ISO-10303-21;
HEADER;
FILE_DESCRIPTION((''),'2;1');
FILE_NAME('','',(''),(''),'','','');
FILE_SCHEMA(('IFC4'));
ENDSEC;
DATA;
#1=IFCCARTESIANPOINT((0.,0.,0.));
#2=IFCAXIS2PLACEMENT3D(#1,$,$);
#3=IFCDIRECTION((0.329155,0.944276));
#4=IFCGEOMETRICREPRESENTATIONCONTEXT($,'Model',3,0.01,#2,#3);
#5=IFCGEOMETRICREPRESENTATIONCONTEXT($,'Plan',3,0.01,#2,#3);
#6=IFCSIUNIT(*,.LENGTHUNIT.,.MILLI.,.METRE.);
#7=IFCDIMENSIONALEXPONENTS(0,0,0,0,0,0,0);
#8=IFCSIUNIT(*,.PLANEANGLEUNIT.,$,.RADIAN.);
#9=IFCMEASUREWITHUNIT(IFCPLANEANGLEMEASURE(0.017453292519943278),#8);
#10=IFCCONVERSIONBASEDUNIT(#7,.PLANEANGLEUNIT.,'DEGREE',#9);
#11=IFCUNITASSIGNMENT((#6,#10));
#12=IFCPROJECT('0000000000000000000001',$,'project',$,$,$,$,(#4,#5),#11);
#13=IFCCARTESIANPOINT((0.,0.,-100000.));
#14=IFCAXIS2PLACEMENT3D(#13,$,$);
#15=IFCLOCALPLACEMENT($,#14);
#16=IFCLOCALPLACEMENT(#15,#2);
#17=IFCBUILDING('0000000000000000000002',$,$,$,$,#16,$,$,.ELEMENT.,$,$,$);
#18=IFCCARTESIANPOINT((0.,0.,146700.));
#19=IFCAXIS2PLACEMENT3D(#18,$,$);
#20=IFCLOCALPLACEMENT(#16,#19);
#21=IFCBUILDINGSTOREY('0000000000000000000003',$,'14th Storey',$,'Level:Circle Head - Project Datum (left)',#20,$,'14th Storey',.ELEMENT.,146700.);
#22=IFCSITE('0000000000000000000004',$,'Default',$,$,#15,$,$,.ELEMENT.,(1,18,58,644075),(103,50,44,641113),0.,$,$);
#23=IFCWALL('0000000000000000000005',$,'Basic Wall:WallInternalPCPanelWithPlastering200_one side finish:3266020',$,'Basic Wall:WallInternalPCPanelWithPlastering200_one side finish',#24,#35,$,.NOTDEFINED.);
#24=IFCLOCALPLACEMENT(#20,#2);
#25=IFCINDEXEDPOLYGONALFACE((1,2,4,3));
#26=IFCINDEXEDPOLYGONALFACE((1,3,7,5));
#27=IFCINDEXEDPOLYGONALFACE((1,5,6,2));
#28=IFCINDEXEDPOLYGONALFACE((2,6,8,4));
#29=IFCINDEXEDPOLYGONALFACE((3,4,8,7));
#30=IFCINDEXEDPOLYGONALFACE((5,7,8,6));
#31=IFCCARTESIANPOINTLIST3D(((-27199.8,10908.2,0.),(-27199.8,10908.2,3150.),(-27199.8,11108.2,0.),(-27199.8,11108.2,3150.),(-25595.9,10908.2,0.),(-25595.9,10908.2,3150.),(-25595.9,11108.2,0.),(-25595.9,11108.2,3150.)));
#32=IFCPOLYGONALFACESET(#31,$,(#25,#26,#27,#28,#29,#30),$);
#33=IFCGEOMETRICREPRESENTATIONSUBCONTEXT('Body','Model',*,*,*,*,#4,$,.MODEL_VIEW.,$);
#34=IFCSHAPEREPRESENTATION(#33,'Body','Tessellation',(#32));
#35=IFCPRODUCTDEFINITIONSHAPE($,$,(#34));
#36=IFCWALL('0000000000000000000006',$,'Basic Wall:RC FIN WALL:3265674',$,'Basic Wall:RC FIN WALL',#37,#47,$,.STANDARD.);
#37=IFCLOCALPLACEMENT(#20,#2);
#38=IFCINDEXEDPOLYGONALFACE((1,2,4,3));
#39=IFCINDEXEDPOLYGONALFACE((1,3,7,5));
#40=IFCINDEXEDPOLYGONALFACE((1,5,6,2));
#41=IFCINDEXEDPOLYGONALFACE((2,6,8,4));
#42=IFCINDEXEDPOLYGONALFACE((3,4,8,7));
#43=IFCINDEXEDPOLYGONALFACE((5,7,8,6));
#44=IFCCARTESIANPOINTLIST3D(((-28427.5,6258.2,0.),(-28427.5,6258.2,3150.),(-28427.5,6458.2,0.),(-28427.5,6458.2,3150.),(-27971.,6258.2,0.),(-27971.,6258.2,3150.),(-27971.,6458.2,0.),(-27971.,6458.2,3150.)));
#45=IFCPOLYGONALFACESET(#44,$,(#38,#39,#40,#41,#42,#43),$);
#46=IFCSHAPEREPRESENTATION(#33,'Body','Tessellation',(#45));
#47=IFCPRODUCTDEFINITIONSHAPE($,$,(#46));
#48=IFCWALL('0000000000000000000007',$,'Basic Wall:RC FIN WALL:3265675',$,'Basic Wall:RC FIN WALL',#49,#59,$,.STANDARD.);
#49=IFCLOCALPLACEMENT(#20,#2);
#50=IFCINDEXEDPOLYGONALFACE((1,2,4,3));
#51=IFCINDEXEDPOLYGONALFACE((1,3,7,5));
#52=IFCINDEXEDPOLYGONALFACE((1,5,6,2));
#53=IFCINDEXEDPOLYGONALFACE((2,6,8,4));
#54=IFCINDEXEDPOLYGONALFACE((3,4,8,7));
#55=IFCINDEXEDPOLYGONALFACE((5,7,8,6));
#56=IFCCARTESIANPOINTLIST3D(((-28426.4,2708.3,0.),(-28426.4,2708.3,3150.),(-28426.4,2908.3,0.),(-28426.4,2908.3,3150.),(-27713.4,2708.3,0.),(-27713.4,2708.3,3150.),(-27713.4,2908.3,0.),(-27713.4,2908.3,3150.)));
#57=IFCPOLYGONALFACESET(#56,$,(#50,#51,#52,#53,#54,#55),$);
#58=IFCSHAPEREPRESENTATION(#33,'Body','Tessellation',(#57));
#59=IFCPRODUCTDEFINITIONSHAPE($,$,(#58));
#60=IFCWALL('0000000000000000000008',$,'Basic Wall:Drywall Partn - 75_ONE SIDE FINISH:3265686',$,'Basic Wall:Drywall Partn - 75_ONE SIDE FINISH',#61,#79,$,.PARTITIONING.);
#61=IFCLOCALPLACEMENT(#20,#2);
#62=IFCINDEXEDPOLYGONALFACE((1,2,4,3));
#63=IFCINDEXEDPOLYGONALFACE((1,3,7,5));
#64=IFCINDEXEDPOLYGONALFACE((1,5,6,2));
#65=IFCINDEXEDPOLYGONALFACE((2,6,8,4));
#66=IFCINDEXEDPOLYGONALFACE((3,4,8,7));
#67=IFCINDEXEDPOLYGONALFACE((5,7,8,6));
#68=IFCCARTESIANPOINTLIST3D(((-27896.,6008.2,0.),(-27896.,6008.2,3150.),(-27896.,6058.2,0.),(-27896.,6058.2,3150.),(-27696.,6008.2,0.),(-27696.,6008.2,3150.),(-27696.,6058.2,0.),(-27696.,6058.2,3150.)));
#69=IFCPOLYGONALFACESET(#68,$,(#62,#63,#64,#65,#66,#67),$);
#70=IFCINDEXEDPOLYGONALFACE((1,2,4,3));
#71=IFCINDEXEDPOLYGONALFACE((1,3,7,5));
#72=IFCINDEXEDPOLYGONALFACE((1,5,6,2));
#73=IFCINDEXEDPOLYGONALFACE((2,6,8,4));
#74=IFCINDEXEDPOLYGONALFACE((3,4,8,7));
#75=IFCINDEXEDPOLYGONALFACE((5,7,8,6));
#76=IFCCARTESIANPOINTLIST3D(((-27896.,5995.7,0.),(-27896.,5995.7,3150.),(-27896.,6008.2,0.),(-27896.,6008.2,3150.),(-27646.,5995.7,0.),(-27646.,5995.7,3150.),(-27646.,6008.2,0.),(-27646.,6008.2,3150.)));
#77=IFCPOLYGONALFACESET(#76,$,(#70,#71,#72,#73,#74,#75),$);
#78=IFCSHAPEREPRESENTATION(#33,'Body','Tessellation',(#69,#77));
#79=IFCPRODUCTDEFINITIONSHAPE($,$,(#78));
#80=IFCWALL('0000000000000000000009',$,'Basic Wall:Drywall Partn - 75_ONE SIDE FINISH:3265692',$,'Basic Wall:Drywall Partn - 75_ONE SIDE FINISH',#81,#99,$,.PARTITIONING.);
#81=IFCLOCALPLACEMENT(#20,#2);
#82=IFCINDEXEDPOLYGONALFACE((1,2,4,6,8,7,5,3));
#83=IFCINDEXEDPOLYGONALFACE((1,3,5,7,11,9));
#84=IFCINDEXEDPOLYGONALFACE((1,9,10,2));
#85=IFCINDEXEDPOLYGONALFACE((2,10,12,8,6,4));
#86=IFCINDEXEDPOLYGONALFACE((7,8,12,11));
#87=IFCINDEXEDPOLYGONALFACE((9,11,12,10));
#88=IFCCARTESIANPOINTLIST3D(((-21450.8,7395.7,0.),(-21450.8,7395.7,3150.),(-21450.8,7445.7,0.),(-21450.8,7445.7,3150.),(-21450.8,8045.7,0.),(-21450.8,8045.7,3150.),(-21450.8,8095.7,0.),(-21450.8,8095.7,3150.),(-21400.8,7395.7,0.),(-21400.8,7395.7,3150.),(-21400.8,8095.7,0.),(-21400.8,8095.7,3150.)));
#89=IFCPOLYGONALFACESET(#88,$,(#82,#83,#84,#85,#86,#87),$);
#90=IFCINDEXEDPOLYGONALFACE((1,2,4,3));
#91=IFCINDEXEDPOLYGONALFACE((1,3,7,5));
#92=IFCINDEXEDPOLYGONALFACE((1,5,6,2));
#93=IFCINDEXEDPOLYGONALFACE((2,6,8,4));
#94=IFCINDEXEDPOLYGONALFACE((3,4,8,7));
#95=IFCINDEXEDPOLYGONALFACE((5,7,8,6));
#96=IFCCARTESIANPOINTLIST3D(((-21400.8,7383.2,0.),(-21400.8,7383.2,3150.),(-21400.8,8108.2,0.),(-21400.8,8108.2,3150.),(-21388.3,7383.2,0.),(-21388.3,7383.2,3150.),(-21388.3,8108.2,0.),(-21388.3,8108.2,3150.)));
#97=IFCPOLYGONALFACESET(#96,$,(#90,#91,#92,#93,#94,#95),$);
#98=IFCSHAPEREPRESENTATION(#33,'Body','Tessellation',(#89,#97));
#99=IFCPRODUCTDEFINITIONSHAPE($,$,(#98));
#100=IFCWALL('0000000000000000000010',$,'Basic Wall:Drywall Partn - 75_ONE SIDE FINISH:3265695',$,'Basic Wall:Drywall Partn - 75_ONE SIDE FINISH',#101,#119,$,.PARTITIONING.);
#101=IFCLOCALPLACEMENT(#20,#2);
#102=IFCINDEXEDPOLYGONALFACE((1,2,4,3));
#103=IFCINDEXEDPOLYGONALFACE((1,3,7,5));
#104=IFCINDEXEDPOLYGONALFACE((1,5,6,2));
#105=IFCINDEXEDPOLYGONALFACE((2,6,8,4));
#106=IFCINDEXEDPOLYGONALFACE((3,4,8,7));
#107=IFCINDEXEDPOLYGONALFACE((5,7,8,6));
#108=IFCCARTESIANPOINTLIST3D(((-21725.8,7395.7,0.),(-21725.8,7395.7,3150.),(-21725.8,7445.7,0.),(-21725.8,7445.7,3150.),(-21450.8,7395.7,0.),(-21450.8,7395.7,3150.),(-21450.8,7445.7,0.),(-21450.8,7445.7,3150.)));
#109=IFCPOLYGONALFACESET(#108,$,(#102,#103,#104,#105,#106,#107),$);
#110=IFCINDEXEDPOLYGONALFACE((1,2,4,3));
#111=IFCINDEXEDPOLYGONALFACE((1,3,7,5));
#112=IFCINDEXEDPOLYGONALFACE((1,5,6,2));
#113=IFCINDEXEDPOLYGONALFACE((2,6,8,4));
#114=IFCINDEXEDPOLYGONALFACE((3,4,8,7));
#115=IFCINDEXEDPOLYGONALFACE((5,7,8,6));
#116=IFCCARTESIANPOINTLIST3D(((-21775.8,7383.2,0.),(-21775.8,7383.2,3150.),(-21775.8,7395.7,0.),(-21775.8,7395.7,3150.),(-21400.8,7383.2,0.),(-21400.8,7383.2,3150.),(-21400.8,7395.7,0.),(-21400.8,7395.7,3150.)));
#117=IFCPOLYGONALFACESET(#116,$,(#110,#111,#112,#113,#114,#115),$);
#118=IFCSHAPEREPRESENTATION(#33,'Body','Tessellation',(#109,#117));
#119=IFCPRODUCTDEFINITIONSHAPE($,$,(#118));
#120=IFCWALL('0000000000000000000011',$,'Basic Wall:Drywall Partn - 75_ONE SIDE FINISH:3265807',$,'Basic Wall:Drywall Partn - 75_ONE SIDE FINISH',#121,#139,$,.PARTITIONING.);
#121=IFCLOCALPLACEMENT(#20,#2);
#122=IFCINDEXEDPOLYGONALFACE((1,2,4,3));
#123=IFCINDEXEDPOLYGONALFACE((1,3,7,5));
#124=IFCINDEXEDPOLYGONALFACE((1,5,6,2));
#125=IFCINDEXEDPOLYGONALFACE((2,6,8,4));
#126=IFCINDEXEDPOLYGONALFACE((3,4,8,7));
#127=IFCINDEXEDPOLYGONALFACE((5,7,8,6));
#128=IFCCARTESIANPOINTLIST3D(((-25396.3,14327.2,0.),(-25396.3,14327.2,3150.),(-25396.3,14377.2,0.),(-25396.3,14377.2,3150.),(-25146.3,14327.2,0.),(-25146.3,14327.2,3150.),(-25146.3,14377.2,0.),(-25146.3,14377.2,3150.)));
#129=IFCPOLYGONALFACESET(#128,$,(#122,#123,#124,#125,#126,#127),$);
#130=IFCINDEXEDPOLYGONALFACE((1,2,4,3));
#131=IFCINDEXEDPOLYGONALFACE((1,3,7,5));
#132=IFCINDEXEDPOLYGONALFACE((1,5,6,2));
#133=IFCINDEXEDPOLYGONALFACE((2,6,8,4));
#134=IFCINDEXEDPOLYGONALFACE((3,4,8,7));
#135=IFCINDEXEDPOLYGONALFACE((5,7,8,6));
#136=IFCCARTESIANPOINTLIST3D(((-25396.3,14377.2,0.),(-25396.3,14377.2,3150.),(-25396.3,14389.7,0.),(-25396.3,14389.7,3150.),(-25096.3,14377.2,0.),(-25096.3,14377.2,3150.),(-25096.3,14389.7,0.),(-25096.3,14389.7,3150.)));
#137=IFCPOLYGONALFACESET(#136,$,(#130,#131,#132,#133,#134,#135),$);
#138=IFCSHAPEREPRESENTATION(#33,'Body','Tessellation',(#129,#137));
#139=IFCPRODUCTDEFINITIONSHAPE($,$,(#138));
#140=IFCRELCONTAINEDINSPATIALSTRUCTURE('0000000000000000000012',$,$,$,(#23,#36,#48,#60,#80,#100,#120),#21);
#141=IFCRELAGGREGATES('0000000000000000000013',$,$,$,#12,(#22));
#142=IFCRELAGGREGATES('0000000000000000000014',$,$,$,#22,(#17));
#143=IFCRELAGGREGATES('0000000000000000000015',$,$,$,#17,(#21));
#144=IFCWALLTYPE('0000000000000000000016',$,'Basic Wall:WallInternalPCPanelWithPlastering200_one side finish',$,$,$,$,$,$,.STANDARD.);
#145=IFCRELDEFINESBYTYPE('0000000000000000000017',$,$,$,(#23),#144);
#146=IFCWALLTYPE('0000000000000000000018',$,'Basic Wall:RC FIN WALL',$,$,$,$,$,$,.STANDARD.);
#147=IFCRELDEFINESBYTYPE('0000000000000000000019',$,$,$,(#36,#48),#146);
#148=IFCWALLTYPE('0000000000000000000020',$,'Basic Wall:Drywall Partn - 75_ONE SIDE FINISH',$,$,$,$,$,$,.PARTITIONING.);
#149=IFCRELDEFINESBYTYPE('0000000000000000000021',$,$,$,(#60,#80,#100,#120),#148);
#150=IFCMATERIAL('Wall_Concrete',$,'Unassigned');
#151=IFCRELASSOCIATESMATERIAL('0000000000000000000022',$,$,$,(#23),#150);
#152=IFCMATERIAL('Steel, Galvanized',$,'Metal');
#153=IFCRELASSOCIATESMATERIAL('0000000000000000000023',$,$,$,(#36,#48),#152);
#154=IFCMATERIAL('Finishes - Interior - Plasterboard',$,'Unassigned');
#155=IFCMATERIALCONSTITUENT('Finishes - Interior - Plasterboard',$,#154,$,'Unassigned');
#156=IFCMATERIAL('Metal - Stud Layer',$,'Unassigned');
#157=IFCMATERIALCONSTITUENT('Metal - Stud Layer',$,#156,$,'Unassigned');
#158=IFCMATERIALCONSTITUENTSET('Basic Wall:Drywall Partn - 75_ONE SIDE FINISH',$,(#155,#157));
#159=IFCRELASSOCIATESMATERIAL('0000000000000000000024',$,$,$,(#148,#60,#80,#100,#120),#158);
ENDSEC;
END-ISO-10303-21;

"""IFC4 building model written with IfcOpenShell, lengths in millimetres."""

from ifc_helpers import new_model, entity, si_unit, converted_unit, direction, frame, origin, place, context, subcontext, project, spatial, indexed_curve, outline, extrude, material, constituent, constituent_set, type_object, element, save


model = new_model("IFC4")

# Units and contexts
model_context = context("Model", 3, precision=0.01, world=origin(), true_north=direction((0.329155, 0.944276)))
plan_context = context("Plan", 3, precision=0.01, world=origin(), true_north=direction((0.329155, 0.944276)))
body_context = subcontext(model_context, "Body", "Model", "MODEL_VIEW")
ifc_project = project(units=[si_unit("LENGTHUNIT", "METRE", prefix="MILLI"), converted_unit("PLANEANGLEUNIT", "DEGREE", entity("IfcPlaneAngleMeasure", 0.017453292519943278), si_unit("PLANEANGLEUNIT", "RADIAN"), dimensions=[0, 0, 0, 0, 0, 0, 0])], contexts=[model_context, plan_context])

# Site, building, storey
site_placement = place(None, frame((0.0, 0.0, -100000.0)))
site = spatial("IfcSite", under=ifc_project, at=site_placement, Name="Default", CompositionType="ELEMENT", RefLatitude=(1, 18, 58, 644075), RefLongitude=(103, 50, 44, 641113), RefElevation=0.0)
building_placement = place(site_placement, origin())
building = spatial("IfcBuilding", under=site, at=building_placement, CompositionType="ELEMENT")
storey_placement = place(building_placement, frame((0.0, 0.0, 146700.0)))
storey = spatial("IfcBuildingStorey", under=building, at=storey_placement, Name="14th Storey", ObjectType="Level:Circle Head - Project Datum (left)", LongName="14th Storey", CompositionType="ELEMENT", Elevation=146700.0)

# Walls
ifc_material_1 = material(Name="Wall_Concrete", Category="Unassigned")
wall_type_1 = type_object("IfcWallType", Name="Basic Wall:WallInternalPCPanelWithPlastering200_one side finish", PredefinedType="STANDARD")
wall_1_placement = place(storey_placement, frame((-27199.8, 11008.2, 0.0)))
element("IfcWall", 1, at=wall_1_placement, inside=storey, type_object=wall_type_1, material=ifc_material_1, Name="Basic Wall:WallInternalPCPanelWithPlastering200_one side finish:3266020", ObjectType="Basic Wall:WallInternalPCPanelWithPlastering200_one side finish", PredefinedType="NOTDEFINED", context=body_context, shape_type="SweptSolid", body=[
    extrude(outline(indexed_curve([(1603.9, 100.0), (0.0, 100.0), (0.0, -100.0), (1603.9, -100.0), (1603.9, 100.0)], self_intersect=False)), origin(), (0.0, 0.0, 1.0), 3150.0),
])
ifc_material_2 = material(Name="Steel, Galvanized", Category="Metal")
wall_type_2 = type_object("IfcWallType", Name="Basic Wall:RC FIN WALL", PredefinedType="STANDARD")
wall_2_placement = place(storey_placement, frame((-27971.0, 6358.2, 0.0), z_axis=(0.0, 0.0, 1.0), x_axis=(-1.0, 0.0, 0.0)))
element("IfcWall", 2, at=wall_2_placement, inside=storey, type_object=wall_type_2, material=ifc_material_2, Name="Basic Wall:RC FIN WALL:3265674", ObjectType="Basic Wall:RC FIN WALL", PredefinedType="STANDARD", context=body_context, shape_type="SweptSolid", body=[
    extrude(outline(indexed_curve([(456.5, 100.0), (0.0, 100.0), (0.0, -100.0), (456.5, -100.0), (456.5, 100.0)], self_intersect=False)), origin(), (0.0, 0.0, 1.0), 3150.0),
])
wall_3_placement = place(storey_placement, frame((-27713.4, 2808.3, 0.0), z_axis=(0.0, 0.0, 1.0), x_axis=(-1.0, 0.0, 0.0)))
element("IfcWall", 3, at=wall_3_placement, inside=storey, type_object=wall_type_2, material=ifc_material_2, Name="Basic Wall:RC FIN WALL:3265675", ObjectType="Basic Wall:RC FIN WALL", PredefinedType="STANDARD", context=body_context, shape_type="SweptSolid", body=[
    extrude(outline(indexed_curve([(713.0, 100.0), (0.0, 100.0), (0.0, -100.0), (713.0, -100.0), (713.0, 100.0)], self_intersect=False)), origin(), (0.0, 0.0, 1.0), 3150.0),
])
ifc_material_3 = material(Name="Finishes - Interior - Plasterboard", Category="Unassigned")
ifc_constituent_1 = constituent(ifc_material_3, Name="Finishes - Interior - Plasterboard", Category="Unassigned")
ifc_material_4 = material(Name="Metal - Stud Layer", Category="Unassigned")
ifc_constituent_2 = constituent(ifc_material_4, Name="Metal - Stud Layer", Category="Unassigned")
ifc_constituent_set = constituent_set(constituents=[ifc_constituent_1, ifc_constituent_2], Name="Basic Wall:Drywall Partn - 75_ONE SIDE FINISH")
wall_type_3 = type_object("IfcWallType", Name="Basic Wall:Drywall Partn - 75_ONE SIDE FINISH", PredefinedType="PARTITIONING", material=ifc_constituent_set)
wall_4_placement = place(storey_placement, frame((-27696.0, 6027.0, 0.0), z_axis=(0.0, 0.0, 1.0), x_axis=(-1.0, 0.0, 0.0)))
element("IfcWall", 4, at=wall_4_placement, inside=storey, type_object=wall_type_3, material=ifc_constituent_set, Name="Basic Wall:Drywall Partn - 75_ONE SIDE FINISH:3265686", ObjectType="Basic Wall:Drywall Partn - 75_ONE SIDE FINISH", PredefinedType="PARTITIONING", context=body_context, shape_type="SweptSolid", body=[
    extrude(outline(indexed_curve([(-25.0, -100.0), (25.0, -100.0), (25.0, 100.0), (-25.0, 100.0), (-25.0, -100.0)], self_intersect=False)), frame((100.0, -6.2, 0.0), z_axis=(0.0, 0.0, 1.0), x_axis=(0.0, 1.0, 0.0)), (0.0, 0.0, 1.0), 3150.0),
    extrude(outline(indexed_curve([(-6.2, -125.0), (6.3, -125.0), (6.3, 125.0), (-6.2, 125.0), (-6.2, -125.0)], self_intersect=False)), frame((75.0, 25.0, 0.0), z_axis=(0.0, 0.0, 1.0), x_axis=(0.0, -1.0, 0.0)), (0.0, 0.0, 1.0), 3150.0),
])
wall_5_placement = place(storey_placement, frame((-21419.6, 7383.2, 0.0), z_axis=(0.0, 0.0, 1.0), x_axis=(0.0, 1.0, 0.0)))
element("IfcWall", 5, at=wall_5_placement, inside=storey, type_object=wall_type_3, material=ifc_constituent_set, Name="Basic Wall:Drywall Partn - 75_ONE SIDE FINISH:3265692", ObjectType="Basic Wall:Drywall Partn - 75_ONE SIDE FINISH", PredefinedType="PARTITIONING", context=body_context, shape_type="SweptSolid", body=[
    extrude(outline(indexed_curve([(-300.0, -16.7), (300.0, -16.7), (350.0, -16.7), (350.0, 33.3), (-350.0, 33.3), (-350.0, -16.7), (-300.0, -16.7)], self_intersect=False)), frame((362.5, 14.6, 0.0), z_axis=(0.0, 0.0, 1.0), x_axis=(-1.0, 0.0, 0.0)), (0.0, 0.0, 1.0), 3150.0),
    extrude(outline(indexed_curve([(-6.2, -362.5), (6.2, -362.5), (6.2, 362.5), (-6.3, 362.5), (-6.2, -362.5)], self_intersect=False)), frame((362.5, -25.0, 0.0), z_axis=(0.0, 0.0, 1.0), x_axis=(0.0, 1.0, 0.0)), (0.0, 0.0, 1.0), 3150.0),
])

# Walls
wall_6_placement = place(storey_placement, frame((-21450.8, 7414.5, 0.0), z_axis=(0.0, 0.0, 1.0), x_axis=(-1.0, 0.0, 0.0)))
element("IfcWall", 6, at=wall_6_placement, inside=storey, type_object=wall_type_3, material=ifc_constituent_set, Name="Basic Wall:Drywall Partn - 75_ONE SIDE FINISH:3265695", ObjectType="Basic Wall:Drywall Partn - 75_ONE SIDE FINISH", PredefinedType="PARTITIONING", context=body_context, shape_type="SweptSolid", body=[
    extrude(outline(indexed_curve([(-25.0, -137.5), (25.0, -137.5), (25.0, 137.5), (-25.0, 137.5), (-25.0, -137.5)], self_intersect=False)), frame((137.5, -6.2, 0.0), z_axis=(0.0, 0.0, 1.0), x_axis=(0.0, 1.0, 0.0)), (0.0, 0.0, 1.0), 3150.0),
    extrude(outline(indexed_curve([(-6.2, -187.5), (6.3, -187.5), (6.2, 187.5), (-6.3, 187.5), (-6.2, -187.5)], self_intersect=False)), frame((137.5, 25.0, 0.0), z_axis=(0.0, 0.0, 1.0), x_axis=(0.0, -1.0, 0.0)), (0.0, 0.0, 1.0), 3150.0),
])
wall_7_placement = place(storey_placement, frame((-25146.3, 14358.4, 0.0), z_axis=(0.0, 0.0, 1.0), x_axis=(-1.0, 0.0, 0.0)))
element("IfcWall", 7, at=wall_7_placement, inside=storey, type_object=wall_type_3, material=ifc_constituent_set, Name="Basic Wall:Drywall Partn - 75_ONE SIDE FINISH:3265807", ObjectType="Basic Wall:Drywall Partn - 75_ONE SIDE FINISH", PredefinedType="PARTITIONING", context=body_context, shape_type="SweptSolid", body=[
    extrude(outline(indexed_curve([(-25.0, -125.0), (25.0, -125.0), (25.0, 125.0), (-25.0, 125.0), (-25.0, -125.0)], self_intersect=False)), frame((125.0, 6.3, 0.0), z_axis=(0.0, 0.0, 1.0), x_axis=(0.0, -1.0, 0.0)), (0.0, 0.0, 1.0), 3150.0),
    extrude(outline(indexed_curve([(-6.3, -150.0), (6.3, -150.0), (6.3, 150.0), (-6.3, 150.0), (-6.3, -150.0)], self_intersect=False)), frame((100.0, -25.0, 0.0), z_axis=(0.0, 0.0, 1.0), x_axis=(0.0, 1.0, 0.0)), (0.0, 0.0, 1.0), 3150.0),
])

save(model, "model.ifc")
